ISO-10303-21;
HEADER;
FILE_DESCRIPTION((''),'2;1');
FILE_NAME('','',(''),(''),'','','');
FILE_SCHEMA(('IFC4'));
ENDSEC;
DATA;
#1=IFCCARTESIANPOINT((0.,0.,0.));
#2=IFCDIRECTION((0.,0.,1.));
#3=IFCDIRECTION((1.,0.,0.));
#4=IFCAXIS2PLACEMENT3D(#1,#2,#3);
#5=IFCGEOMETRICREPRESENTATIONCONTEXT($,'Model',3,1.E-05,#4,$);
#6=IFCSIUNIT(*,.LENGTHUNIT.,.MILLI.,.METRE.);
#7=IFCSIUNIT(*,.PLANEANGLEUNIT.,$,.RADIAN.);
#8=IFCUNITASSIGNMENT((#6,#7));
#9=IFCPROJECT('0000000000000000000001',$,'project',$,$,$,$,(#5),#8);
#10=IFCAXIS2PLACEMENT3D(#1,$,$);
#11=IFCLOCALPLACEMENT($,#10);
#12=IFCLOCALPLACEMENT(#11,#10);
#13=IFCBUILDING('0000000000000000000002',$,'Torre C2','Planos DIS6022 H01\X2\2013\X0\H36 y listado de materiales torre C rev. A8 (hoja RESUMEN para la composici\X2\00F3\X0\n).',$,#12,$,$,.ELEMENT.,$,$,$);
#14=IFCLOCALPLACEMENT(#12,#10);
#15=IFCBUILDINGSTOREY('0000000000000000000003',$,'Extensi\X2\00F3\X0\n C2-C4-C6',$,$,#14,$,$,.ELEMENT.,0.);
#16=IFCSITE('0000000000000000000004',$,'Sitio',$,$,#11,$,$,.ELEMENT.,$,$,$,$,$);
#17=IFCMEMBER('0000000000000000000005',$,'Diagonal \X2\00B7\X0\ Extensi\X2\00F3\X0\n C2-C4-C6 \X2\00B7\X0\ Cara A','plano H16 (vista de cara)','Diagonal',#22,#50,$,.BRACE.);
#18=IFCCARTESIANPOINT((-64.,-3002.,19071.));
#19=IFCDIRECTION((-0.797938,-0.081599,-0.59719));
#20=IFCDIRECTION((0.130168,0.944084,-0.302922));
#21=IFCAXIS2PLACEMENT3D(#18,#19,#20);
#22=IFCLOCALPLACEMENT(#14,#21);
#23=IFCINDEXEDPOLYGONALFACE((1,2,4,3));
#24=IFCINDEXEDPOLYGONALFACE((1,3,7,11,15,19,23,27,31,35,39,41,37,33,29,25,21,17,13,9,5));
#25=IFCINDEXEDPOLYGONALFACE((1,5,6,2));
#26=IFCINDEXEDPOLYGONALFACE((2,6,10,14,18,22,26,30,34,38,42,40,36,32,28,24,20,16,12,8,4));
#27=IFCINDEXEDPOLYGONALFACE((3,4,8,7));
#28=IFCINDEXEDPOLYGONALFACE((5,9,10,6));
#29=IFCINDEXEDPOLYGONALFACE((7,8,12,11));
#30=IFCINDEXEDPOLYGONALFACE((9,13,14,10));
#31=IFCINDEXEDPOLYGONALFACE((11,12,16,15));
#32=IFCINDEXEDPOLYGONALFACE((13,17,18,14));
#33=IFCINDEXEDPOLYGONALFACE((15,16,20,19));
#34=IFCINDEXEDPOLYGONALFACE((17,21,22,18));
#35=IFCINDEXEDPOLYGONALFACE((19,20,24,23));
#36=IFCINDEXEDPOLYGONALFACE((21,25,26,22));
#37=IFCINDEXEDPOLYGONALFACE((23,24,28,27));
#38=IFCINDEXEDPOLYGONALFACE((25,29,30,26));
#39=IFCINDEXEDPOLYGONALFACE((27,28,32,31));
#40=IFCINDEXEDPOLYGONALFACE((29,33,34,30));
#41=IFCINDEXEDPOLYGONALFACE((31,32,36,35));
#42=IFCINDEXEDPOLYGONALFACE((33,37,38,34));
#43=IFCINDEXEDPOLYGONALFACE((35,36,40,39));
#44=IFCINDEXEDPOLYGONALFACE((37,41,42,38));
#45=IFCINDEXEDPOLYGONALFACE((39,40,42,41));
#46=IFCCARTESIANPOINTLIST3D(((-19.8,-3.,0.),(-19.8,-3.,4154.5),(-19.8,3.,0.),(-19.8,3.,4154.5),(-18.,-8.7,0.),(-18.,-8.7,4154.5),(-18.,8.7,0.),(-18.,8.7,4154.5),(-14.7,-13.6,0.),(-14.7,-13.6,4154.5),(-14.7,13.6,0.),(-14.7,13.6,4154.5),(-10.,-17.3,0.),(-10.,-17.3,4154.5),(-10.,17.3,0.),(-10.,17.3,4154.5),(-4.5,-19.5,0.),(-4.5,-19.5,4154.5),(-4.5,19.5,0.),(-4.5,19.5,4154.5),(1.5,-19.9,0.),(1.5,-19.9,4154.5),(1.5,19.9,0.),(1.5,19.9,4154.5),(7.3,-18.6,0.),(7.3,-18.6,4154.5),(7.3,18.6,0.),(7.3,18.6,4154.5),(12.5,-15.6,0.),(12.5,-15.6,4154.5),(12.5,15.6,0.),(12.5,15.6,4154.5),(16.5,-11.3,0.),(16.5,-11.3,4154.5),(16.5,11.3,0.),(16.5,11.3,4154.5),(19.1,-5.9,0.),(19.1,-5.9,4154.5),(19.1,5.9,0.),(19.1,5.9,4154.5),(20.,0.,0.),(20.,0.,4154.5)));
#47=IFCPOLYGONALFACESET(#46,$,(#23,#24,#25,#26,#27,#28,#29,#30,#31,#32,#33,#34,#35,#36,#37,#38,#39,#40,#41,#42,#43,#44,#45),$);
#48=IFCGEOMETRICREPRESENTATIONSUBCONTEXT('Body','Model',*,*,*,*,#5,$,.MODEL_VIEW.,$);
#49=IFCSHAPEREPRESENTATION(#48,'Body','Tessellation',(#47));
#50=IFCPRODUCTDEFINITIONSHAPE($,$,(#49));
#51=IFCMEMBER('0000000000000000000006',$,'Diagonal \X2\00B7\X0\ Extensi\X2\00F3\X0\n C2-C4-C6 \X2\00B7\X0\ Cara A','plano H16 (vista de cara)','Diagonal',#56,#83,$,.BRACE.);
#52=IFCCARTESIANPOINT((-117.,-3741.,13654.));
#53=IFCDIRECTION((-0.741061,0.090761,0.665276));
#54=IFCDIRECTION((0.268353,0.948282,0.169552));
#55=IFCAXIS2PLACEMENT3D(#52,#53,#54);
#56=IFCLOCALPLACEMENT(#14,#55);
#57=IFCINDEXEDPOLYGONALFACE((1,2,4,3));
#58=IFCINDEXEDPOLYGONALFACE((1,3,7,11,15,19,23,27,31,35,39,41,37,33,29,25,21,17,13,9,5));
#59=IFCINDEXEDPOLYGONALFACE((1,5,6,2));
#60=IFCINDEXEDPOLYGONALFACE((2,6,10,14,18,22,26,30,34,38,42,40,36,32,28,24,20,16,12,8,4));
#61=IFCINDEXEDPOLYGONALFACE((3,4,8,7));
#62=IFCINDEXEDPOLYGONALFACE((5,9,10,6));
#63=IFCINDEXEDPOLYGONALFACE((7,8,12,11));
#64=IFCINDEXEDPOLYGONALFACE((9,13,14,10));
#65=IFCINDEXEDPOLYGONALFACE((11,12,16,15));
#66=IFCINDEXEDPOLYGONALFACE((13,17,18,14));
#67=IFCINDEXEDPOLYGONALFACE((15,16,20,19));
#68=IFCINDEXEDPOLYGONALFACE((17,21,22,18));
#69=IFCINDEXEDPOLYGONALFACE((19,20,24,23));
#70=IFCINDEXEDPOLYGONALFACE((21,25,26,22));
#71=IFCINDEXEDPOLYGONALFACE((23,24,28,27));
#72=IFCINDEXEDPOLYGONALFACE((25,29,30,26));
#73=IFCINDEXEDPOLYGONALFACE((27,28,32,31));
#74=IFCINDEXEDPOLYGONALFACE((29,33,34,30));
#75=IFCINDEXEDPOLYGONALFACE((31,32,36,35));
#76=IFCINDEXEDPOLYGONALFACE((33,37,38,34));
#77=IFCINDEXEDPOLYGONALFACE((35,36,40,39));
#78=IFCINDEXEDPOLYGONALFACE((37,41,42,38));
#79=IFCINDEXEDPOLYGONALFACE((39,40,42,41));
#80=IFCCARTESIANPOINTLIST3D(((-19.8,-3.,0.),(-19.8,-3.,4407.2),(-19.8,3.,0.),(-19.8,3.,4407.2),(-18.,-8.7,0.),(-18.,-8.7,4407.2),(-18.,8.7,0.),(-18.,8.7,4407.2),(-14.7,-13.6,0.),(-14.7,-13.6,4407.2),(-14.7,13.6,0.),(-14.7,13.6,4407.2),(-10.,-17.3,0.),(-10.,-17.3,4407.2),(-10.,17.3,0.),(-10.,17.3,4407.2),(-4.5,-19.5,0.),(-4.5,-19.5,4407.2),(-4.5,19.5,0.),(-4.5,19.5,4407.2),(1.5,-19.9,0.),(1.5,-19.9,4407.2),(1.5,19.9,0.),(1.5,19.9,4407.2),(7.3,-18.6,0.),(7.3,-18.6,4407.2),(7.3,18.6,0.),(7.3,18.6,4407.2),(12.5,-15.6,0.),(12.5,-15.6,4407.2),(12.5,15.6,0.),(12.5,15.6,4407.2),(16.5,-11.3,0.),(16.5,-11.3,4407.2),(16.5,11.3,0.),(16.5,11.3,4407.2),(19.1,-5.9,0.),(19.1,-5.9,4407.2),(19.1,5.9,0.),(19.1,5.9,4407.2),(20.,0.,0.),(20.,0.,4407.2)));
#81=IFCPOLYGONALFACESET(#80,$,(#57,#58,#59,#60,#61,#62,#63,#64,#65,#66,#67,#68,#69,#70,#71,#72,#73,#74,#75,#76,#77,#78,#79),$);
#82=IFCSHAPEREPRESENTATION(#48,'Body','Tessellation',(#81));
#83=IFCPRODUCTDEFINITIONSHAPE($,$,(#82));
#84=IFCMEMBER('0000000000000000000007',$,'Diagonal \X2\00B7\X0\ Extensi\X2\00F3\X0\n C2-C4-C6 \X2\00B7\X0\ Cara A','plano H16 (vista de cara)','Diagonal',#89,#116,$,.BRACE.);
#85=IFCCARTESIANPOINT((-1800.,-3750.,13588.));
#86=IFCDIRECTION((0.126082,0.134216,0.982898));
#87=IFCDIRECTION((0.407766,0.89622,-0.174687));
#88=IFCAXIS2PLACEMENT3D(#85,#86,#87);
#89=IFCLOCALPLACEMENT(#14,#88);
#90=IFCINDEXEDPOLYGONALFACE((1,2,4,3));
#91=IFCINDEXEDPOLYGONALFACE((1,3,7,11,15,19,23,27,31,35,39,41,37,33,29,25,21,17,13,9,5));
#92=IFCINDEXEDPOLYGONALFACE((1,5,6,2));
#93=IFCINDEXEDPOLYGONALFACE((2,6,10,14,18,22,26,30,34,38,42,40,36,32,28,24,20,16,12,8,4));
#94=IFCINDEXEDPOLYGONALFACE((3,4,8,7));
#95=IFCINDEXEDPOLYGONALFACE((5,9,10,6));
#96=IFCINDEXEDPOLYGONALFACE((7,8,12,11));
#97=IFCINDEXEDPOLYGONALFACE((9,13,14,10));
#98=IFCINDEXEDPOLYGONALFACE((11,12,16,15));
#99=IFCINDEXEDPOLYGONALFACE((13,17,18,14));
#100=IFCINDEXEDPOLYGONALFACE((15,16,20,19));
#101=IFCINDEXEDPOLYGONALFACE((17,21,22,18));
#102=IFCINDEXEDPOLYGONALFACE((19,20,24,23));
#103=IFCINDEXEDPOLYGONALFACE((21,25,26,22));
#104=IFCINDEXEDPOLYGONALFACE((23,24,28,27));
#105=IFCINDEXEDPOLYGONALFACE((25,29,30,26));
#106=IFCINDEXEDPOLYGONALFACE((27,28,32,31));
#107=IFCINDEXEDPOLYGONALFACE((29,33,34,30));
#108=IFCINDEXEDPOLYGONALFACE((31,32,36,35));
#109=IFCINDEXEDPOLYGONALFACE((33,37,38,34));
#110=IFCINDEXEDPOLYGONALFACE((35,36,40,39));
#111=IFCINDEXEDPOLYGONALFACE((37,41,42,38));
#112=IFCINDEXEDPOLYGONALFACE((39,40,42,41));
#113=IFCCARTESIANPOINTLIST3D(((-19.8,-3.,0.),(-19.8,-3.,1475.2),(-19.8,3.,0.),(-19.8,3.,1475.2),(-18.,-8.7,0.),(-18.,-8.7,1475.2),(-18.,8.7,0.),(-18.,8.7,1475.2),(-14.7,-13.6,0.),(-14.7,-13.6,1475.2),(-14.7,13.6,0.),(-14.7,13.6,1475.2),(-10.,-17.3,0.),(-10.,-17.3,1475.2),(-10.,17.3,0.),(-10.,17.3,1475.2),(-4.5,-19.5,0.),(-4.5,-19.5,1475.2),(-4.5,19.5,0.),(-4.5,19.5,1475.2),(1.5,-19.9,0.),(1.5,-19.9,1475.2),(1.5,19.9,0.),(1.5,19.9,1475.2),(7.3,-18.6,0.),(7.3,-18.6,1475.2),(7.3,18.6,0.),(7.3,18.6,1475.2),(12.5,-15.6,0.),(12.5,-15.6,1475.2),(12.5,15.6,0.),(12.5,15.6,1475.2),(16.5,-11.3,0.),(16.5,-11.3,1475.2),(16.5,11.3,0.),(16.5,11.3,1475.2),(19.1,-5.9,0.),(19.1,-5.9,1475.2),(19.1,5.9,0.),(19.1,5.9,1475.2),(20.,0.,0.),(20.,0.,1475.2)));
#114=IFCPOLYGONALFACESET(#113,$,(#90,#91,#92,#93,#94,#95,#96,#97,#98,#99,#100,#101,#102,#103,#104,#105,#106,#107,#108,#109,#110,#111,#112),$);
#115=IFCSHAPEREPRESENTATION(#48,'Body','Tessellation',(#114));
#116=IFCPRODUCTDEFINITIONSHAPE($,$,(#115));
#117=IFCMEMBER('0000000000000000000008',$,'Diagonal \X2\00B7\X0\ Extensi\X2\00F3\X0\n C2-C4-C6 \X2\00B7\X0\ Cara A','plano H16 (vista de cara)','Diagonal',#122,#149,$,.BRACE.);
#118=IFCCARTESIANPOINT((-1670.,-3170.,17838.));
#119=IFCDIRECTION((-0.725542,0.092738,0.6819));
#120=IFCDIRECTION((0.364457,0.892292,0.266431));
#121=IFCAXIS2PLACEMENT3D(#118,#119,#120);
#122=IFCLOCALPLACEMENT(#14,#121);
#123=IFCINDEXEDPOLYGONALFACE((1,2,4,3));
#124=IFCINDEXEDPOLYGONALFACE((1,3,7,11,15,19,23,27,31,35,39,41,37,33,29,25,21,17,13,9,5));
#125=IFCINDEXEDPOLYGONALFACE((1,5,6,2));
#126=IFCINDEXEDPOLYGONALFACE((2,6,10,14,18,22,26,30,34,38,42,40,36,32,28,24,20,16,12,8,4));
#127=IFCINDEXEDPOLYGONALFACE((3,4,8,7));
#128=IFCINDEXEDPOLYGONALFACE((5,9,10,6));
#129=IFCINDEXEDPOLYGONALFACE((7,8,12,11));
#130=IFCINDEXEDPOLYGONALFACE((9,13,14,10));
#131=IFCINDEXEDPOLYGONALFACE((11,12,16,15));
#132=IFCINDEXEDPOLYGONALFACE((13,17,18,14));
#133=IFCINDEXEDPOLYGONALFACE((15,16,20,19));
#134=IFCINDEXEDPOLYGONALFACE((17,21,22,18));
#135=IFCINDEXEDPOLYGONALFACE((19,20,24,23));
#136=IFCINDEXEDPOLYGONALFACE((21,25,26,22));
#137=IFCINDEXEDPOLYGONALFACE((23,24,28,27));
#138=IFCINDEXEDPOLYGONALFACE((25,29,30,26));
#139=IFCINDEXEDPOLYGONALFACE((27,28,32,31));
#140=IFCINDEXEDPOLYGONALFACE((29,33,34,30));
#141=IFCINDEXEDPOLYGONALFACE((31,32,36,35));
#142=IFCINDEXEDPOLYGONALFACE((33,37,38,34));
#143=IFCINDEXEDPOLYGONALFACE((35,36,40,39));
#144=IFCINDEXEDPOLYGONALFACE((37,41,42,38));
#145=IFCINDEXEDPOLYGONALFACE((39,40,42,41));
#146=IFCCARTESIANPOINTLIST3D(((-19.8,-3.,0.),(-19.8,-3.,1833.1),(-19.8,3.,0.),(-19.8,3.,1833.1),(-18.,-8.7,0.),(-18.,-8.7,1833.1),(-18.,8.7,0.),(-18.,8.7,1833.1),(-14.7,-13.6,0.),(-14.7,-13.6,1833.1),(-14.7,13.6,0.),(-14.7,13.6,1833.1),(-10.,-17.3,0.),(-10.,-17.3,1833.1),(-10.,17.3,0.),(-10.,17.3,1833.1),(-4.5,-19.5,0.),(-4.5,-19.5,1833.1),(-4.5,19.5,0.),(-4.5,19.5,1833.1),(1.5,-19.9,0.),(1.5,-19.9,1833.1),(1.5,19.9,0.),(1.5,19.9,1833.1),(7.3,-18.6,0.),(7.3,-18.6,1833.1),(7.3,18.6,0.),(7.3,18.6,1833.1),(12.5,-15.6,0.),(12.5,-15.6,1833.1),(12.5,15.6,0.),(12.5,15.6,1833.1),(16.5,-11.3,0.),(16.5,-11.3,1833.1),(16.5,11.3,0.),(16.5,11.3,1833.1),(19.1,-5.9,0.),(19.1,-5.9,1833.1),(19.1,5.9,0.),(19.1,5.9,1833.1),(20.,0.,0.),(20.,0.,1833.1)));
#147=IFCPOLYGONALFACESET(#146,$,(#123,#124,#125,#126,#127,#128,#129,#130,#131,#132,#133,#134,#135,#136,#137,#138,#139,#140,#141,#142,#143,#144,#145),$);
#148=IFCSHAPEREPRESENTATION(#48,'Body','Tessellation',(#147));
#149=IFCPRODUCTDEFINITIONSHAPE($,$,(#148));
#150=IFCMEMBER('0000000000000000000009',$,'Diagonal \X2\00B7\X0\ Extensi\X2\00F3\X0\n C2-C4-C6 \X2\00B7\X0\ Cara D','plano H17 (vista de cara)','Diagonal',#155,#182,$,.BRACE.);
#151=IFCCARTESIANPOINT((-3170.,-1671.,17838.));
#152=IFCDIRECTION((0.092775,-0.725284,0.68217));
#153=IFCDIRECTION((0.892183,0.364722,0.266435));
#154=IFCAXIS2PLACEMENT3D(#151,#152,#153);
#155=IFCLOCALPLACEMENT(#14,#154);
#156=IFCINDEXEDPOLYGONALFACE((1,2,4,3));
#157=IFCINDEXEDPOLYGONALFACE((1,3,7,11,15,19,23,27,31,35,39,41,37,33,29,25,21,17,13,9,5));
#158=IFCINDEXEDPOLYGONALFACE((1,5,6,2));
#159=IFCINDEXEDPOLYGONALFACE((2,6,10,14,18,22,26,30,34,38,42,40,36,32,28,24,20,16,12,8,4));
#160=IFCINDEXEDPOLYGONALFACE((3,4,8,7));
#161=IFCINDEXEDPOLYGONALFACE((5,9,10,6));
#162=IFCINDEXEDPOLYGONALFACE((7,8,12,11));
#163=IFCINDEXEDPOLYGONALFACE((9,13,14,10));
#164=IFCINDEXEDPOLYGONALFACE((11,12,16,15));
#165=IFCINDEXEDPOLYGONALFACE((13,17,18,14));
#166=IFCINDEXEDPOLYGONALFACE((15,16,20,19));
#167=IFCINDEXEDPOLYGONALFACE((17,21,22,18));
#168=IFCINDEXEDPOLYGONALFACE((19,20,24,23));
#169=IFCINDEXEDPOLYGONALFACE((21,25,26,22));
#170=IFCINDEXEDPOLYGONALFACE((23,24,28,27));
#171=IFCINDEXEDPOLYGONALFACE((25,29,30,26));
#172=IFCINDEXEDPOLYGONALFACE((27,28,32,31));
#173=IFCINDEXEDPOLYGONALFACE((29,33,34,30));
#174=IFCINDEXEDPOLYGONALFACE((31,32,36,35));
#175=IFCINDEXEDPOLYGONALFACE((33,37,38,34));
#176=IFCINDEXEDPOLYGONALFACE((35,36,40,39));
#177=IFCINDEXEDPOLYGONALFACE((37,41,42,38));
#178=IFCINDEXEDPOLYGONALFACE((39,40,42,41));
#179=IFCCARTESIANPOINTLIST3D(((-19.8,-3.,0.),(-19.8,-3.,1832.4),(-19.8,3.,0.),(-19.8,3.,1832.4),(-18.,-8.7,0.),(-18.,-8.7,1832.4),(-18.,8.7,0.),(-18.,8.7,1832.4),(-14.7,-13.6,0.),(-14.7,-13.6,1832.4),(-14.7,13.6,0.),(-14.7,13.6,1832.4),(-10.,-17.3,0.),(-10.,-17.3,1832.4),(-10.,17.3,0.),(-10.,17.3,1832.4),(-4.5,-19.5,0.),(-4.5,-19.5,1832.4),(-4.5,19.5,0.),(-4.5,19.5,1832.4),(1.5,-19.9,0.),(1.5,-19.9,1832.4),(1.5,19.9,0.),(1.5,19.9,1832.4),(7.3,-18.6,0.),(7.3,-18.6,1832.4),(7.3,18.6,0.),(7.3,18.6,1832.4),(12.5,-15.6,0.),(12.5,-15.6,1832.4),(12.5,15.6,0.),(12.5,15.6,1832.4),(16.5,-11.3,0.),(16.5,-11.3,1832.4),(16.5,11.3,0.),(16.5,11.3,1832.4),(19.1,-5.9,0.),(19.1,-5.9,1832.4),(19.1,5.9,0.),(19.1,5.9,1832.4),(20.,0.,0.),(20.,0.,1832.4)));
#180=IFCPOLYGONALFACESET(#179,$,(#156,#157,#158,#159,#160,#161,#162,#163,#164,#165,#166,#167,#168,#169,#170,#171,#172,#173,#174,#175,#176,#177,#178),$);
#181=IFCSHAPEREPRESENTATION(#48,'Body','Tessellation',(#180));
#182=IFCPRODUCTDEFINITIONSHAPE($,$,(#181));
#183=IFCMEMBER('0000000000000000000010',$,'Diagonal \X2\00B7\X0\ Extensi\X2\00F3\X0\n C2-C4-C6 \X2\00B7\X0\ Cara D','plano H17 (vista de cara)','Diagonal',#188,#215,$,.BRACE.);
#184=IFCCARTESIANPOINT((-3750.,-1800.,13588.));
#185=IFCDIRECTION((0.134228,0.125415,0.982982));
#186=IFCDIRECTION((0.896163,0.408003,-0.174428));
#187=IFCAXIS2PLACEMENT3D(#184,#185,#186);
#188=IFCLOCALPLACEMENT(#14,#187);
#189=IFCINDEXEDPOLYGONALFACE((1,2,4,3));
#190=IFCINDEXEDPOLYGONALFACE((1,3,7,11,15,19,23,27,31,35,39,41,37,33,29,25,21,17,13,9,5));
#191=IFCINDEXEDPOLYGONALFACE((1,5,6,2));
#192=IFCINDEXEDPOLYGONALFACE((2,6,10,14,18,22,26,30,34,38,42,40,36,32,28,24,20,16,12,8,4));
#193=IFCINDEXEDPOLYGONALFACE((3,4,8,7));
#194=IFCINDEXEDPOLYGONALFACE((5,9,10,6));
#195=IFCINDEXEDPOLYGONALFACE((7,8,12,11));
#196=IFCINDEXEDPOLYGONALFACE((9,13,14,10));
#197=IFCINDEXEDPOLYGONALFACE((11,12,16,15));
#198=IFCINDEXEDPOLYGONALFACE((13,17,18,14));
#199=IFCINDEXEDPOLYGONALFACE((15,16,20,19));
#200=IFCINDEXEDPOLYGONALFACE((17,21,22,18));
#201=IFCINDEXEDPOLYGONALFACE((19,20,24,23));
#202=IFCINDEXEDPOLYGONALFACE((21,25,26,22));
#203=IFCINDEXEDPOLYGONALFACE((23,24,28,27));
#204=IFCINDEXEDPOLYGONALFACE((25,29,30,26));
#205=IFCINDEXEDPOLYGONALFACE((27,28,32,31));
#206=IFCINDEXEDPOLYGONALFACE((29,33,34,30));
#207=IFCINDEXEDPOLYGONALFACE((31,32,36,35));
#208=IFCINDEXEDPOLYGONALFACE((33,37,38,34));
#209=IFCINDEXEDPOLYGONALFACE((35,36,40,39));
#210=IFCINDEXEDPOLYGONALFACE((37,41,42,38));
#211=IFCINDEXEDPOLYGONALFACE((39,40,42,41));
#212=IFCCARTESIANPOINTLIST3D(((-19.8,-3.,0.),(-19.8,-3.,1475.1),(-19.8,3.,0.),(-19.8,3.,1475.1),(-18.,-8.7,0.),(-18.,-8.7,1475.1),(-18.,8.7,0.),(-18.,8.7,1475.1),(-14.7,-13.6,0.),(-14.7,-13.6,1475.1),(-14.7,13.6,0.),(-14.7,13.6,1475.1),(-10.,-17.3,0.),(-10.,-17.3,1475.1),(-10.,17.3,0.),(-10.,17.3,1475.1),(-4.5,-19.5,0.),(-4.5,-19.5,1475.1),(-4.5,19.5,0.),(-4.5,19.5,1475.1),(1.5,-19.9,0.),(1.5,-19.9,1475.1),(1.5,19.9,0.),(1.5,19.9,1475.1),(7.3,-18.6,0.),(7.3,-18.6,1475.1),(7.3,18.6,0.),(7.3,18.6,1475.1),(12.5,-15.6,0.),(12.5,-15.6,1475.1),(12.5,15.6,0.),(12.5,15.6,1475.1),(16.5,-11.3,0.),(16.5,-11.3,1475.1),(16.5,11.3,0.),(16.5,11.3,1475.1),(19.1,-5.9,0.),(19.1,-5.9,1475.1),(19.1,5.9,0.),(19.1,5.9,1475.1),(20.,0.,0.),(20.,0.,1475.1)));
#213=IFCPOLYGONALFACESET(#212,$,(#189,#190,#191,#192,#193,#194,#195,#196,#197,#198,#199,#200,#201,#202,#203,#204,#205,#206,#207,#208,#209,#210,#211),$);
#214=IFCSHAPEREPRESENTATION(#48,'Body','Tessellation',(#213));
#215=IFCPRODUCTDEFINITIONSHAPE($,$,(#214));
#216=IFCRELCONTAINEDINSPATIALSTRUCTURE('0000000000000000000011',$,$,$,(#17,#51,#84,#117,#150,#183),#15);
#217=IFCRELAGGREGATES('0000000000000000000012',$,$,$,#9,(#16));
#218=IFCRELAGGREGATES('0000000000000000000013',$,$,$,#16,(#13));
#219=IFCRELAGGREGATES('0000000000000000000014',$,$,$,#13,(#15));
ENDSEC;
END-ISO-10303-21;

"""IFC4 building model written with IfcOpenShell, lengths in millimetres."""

from ifc_helpers import new_model, si_unit, frame, origin, origin_with_axes, place, context, subcontext, project, spatial, circle, extrude, element, save


model = new_model("IFC4")

# Units and contexts
model_context = context("Model", 3, precision=1e-05, world=origin_with_axes())
body_context = subcontext(model_context, "Body", "Model", "MODEL_VIEW")
ifc_project = project(units=[si_unit("LENGTHUNIT", "METRE", prefix="MILLI"), si_unit("PLANEANGLEUNIT", "RADIAN")], contexts=[model_context])

# Site, building, storey
site_placement = place(None, origin())
site = spatial("IfcSite", under=ifc_project, at=site_placement, Name="Sitio", CompositionType="ELEMENT")
building_placement = place(site_placement, origin())
building = spatial("IfcBuilding", under=site, at=building_placement, Name="Torre C2", Description="Planos DIS6022 H01–H36 y listado de materiales torre C rev. A8 (hoja RESUMEN para la composición).", CompositionType="ELEMENT")
storey_placement = place(building_placement, origin())
storey = spatial("IfcBuildingStorey", under=building, at=storey_placement, Name="Extensión C2-C4-C6", CompositionType="ELEMENT", Elevation=0.0)

# Members
member_1_placement = place(storey_placement, frame((-64.0, -3002.0, 19071.0), z_axis=(-0.797938, -0.081599, -0.59719), x_axis=(0.130168, 0.944084, -0.302922)))
element("IfcMember", 1, at=member_1_placement, inside=storey, Name="Diagonal · Extensión C2-C4-C6 · Cara A", Description="plano H16 (vista de cara)", ObjectType="Diagonal", PredefinedType="BRACE", context=body_context, shape_type="SweptSolid", body=[
    extrude(circle(Radius=20.0), None, (0.0, 0.0, 1.0), 4154.5),
])
member_2_placement = place(storey_placement, frame((-117.0, -3741.0, 13654.0), z_axis=(-0.741061, 0.090761, 0.665276), x_axis=(0.268353, 0.948282, 0.169552)))
element("IfcMember", 2, at=member_2_placement, inside=storey, Name="Diagonal · Extensión C2-C4-C6 · Cara A", Description="plano H16 (vista de cara)", ObjectType="Diagonal", PredefinedType="BRACE", context=body_context, shape_type="SweptSolid", body=[
    extrude(circle(Radius=20.0), None, (0.0, 0.0, 1.0), 4407.2),
])
member_3_placement = place(storey_placement, frame((-1800.0, -3750.0, 13588.0), z_axis=(0.126082, 0.134216, 0.982898), x_axis=(0.407766, 0.89622, -0.174687)))
element("IfcMember", 3, at=member_3_placement, inside=storey, Name="Diagonal · Extensión C2-C4-C6 · Cara A", Description="plano H16 (vista de cara)", ObjectType="Diagonal", PredefinedType="BRACE", context=body_context, shape_type="SweptSolid", body=[
    extrude(circle(Radius=20.0), None, (0.0, 0.0, 1.0), 1475.2),
])
member_4_placement = place(storey_placement, frame((-1670.0, -3170.0, 17838.0), z_axis=(-0.725542, 0.092738, 0.6819), x_axis=(0.364457, 0.892292, 0.266431)))
element("IfcMember", 4, at=member_4_placement, inside=storey, Name="Diagonal · Extensión C2-C4-C6 · Cara A", Description="plano H16 (vista de cara)", ObjectType="Diagonal", PredefinedType="BRACE", context=body_context, shape_type="SweptSolid", body=[
    extrude(circle(Radius=20.0), None, (0.0, 0.0, 1.0), 1833.1),
])
member_5_placement = place(storey_placement, frame((-3170.0, -1671.0, 17838.0), z_axis=(0.092775, -0.725284, 0.68217), x_axis=(0.892183, 0.364722, 0.266435)))
element("IfcMember", 5, at=member_5_placement, inside=storey, Name="Diagonal · Extensión C2-C4-C6 · Cara D", Description="plano H17 (vista de cara)", ObjectType="Diagonal", PredefinedType="BRACE", context=body_context, shape_type="SweptSolid", body=[
    extrude(circle(Radius=20.0), None, (0.0, 0.0, 1.0), 1832.4),
])
member_6_placement = place(storey_placement, frame((-3750.0, -1800.0, 13588.0), z_axis=(0.134228, 0.125415, 0.982982), x_axis=(0.896163, 0.408003, -0.174428)))
element("IfcMember", 6, at=member_6_placement, inside=storey, Name="Diagonal · Extensión C2-C4-C6 · Cara D", Description="plano H17 (vista de cara)", ObjectType="Diagonal", PredefinedType="BRACE", context=body_context, shape_type="SweptSolid", body=[
    extrude(circle(Radius=20.0), None, (0.0, 0.0, 1.0), 1475.1),
])

save(model, "model.ifc")
